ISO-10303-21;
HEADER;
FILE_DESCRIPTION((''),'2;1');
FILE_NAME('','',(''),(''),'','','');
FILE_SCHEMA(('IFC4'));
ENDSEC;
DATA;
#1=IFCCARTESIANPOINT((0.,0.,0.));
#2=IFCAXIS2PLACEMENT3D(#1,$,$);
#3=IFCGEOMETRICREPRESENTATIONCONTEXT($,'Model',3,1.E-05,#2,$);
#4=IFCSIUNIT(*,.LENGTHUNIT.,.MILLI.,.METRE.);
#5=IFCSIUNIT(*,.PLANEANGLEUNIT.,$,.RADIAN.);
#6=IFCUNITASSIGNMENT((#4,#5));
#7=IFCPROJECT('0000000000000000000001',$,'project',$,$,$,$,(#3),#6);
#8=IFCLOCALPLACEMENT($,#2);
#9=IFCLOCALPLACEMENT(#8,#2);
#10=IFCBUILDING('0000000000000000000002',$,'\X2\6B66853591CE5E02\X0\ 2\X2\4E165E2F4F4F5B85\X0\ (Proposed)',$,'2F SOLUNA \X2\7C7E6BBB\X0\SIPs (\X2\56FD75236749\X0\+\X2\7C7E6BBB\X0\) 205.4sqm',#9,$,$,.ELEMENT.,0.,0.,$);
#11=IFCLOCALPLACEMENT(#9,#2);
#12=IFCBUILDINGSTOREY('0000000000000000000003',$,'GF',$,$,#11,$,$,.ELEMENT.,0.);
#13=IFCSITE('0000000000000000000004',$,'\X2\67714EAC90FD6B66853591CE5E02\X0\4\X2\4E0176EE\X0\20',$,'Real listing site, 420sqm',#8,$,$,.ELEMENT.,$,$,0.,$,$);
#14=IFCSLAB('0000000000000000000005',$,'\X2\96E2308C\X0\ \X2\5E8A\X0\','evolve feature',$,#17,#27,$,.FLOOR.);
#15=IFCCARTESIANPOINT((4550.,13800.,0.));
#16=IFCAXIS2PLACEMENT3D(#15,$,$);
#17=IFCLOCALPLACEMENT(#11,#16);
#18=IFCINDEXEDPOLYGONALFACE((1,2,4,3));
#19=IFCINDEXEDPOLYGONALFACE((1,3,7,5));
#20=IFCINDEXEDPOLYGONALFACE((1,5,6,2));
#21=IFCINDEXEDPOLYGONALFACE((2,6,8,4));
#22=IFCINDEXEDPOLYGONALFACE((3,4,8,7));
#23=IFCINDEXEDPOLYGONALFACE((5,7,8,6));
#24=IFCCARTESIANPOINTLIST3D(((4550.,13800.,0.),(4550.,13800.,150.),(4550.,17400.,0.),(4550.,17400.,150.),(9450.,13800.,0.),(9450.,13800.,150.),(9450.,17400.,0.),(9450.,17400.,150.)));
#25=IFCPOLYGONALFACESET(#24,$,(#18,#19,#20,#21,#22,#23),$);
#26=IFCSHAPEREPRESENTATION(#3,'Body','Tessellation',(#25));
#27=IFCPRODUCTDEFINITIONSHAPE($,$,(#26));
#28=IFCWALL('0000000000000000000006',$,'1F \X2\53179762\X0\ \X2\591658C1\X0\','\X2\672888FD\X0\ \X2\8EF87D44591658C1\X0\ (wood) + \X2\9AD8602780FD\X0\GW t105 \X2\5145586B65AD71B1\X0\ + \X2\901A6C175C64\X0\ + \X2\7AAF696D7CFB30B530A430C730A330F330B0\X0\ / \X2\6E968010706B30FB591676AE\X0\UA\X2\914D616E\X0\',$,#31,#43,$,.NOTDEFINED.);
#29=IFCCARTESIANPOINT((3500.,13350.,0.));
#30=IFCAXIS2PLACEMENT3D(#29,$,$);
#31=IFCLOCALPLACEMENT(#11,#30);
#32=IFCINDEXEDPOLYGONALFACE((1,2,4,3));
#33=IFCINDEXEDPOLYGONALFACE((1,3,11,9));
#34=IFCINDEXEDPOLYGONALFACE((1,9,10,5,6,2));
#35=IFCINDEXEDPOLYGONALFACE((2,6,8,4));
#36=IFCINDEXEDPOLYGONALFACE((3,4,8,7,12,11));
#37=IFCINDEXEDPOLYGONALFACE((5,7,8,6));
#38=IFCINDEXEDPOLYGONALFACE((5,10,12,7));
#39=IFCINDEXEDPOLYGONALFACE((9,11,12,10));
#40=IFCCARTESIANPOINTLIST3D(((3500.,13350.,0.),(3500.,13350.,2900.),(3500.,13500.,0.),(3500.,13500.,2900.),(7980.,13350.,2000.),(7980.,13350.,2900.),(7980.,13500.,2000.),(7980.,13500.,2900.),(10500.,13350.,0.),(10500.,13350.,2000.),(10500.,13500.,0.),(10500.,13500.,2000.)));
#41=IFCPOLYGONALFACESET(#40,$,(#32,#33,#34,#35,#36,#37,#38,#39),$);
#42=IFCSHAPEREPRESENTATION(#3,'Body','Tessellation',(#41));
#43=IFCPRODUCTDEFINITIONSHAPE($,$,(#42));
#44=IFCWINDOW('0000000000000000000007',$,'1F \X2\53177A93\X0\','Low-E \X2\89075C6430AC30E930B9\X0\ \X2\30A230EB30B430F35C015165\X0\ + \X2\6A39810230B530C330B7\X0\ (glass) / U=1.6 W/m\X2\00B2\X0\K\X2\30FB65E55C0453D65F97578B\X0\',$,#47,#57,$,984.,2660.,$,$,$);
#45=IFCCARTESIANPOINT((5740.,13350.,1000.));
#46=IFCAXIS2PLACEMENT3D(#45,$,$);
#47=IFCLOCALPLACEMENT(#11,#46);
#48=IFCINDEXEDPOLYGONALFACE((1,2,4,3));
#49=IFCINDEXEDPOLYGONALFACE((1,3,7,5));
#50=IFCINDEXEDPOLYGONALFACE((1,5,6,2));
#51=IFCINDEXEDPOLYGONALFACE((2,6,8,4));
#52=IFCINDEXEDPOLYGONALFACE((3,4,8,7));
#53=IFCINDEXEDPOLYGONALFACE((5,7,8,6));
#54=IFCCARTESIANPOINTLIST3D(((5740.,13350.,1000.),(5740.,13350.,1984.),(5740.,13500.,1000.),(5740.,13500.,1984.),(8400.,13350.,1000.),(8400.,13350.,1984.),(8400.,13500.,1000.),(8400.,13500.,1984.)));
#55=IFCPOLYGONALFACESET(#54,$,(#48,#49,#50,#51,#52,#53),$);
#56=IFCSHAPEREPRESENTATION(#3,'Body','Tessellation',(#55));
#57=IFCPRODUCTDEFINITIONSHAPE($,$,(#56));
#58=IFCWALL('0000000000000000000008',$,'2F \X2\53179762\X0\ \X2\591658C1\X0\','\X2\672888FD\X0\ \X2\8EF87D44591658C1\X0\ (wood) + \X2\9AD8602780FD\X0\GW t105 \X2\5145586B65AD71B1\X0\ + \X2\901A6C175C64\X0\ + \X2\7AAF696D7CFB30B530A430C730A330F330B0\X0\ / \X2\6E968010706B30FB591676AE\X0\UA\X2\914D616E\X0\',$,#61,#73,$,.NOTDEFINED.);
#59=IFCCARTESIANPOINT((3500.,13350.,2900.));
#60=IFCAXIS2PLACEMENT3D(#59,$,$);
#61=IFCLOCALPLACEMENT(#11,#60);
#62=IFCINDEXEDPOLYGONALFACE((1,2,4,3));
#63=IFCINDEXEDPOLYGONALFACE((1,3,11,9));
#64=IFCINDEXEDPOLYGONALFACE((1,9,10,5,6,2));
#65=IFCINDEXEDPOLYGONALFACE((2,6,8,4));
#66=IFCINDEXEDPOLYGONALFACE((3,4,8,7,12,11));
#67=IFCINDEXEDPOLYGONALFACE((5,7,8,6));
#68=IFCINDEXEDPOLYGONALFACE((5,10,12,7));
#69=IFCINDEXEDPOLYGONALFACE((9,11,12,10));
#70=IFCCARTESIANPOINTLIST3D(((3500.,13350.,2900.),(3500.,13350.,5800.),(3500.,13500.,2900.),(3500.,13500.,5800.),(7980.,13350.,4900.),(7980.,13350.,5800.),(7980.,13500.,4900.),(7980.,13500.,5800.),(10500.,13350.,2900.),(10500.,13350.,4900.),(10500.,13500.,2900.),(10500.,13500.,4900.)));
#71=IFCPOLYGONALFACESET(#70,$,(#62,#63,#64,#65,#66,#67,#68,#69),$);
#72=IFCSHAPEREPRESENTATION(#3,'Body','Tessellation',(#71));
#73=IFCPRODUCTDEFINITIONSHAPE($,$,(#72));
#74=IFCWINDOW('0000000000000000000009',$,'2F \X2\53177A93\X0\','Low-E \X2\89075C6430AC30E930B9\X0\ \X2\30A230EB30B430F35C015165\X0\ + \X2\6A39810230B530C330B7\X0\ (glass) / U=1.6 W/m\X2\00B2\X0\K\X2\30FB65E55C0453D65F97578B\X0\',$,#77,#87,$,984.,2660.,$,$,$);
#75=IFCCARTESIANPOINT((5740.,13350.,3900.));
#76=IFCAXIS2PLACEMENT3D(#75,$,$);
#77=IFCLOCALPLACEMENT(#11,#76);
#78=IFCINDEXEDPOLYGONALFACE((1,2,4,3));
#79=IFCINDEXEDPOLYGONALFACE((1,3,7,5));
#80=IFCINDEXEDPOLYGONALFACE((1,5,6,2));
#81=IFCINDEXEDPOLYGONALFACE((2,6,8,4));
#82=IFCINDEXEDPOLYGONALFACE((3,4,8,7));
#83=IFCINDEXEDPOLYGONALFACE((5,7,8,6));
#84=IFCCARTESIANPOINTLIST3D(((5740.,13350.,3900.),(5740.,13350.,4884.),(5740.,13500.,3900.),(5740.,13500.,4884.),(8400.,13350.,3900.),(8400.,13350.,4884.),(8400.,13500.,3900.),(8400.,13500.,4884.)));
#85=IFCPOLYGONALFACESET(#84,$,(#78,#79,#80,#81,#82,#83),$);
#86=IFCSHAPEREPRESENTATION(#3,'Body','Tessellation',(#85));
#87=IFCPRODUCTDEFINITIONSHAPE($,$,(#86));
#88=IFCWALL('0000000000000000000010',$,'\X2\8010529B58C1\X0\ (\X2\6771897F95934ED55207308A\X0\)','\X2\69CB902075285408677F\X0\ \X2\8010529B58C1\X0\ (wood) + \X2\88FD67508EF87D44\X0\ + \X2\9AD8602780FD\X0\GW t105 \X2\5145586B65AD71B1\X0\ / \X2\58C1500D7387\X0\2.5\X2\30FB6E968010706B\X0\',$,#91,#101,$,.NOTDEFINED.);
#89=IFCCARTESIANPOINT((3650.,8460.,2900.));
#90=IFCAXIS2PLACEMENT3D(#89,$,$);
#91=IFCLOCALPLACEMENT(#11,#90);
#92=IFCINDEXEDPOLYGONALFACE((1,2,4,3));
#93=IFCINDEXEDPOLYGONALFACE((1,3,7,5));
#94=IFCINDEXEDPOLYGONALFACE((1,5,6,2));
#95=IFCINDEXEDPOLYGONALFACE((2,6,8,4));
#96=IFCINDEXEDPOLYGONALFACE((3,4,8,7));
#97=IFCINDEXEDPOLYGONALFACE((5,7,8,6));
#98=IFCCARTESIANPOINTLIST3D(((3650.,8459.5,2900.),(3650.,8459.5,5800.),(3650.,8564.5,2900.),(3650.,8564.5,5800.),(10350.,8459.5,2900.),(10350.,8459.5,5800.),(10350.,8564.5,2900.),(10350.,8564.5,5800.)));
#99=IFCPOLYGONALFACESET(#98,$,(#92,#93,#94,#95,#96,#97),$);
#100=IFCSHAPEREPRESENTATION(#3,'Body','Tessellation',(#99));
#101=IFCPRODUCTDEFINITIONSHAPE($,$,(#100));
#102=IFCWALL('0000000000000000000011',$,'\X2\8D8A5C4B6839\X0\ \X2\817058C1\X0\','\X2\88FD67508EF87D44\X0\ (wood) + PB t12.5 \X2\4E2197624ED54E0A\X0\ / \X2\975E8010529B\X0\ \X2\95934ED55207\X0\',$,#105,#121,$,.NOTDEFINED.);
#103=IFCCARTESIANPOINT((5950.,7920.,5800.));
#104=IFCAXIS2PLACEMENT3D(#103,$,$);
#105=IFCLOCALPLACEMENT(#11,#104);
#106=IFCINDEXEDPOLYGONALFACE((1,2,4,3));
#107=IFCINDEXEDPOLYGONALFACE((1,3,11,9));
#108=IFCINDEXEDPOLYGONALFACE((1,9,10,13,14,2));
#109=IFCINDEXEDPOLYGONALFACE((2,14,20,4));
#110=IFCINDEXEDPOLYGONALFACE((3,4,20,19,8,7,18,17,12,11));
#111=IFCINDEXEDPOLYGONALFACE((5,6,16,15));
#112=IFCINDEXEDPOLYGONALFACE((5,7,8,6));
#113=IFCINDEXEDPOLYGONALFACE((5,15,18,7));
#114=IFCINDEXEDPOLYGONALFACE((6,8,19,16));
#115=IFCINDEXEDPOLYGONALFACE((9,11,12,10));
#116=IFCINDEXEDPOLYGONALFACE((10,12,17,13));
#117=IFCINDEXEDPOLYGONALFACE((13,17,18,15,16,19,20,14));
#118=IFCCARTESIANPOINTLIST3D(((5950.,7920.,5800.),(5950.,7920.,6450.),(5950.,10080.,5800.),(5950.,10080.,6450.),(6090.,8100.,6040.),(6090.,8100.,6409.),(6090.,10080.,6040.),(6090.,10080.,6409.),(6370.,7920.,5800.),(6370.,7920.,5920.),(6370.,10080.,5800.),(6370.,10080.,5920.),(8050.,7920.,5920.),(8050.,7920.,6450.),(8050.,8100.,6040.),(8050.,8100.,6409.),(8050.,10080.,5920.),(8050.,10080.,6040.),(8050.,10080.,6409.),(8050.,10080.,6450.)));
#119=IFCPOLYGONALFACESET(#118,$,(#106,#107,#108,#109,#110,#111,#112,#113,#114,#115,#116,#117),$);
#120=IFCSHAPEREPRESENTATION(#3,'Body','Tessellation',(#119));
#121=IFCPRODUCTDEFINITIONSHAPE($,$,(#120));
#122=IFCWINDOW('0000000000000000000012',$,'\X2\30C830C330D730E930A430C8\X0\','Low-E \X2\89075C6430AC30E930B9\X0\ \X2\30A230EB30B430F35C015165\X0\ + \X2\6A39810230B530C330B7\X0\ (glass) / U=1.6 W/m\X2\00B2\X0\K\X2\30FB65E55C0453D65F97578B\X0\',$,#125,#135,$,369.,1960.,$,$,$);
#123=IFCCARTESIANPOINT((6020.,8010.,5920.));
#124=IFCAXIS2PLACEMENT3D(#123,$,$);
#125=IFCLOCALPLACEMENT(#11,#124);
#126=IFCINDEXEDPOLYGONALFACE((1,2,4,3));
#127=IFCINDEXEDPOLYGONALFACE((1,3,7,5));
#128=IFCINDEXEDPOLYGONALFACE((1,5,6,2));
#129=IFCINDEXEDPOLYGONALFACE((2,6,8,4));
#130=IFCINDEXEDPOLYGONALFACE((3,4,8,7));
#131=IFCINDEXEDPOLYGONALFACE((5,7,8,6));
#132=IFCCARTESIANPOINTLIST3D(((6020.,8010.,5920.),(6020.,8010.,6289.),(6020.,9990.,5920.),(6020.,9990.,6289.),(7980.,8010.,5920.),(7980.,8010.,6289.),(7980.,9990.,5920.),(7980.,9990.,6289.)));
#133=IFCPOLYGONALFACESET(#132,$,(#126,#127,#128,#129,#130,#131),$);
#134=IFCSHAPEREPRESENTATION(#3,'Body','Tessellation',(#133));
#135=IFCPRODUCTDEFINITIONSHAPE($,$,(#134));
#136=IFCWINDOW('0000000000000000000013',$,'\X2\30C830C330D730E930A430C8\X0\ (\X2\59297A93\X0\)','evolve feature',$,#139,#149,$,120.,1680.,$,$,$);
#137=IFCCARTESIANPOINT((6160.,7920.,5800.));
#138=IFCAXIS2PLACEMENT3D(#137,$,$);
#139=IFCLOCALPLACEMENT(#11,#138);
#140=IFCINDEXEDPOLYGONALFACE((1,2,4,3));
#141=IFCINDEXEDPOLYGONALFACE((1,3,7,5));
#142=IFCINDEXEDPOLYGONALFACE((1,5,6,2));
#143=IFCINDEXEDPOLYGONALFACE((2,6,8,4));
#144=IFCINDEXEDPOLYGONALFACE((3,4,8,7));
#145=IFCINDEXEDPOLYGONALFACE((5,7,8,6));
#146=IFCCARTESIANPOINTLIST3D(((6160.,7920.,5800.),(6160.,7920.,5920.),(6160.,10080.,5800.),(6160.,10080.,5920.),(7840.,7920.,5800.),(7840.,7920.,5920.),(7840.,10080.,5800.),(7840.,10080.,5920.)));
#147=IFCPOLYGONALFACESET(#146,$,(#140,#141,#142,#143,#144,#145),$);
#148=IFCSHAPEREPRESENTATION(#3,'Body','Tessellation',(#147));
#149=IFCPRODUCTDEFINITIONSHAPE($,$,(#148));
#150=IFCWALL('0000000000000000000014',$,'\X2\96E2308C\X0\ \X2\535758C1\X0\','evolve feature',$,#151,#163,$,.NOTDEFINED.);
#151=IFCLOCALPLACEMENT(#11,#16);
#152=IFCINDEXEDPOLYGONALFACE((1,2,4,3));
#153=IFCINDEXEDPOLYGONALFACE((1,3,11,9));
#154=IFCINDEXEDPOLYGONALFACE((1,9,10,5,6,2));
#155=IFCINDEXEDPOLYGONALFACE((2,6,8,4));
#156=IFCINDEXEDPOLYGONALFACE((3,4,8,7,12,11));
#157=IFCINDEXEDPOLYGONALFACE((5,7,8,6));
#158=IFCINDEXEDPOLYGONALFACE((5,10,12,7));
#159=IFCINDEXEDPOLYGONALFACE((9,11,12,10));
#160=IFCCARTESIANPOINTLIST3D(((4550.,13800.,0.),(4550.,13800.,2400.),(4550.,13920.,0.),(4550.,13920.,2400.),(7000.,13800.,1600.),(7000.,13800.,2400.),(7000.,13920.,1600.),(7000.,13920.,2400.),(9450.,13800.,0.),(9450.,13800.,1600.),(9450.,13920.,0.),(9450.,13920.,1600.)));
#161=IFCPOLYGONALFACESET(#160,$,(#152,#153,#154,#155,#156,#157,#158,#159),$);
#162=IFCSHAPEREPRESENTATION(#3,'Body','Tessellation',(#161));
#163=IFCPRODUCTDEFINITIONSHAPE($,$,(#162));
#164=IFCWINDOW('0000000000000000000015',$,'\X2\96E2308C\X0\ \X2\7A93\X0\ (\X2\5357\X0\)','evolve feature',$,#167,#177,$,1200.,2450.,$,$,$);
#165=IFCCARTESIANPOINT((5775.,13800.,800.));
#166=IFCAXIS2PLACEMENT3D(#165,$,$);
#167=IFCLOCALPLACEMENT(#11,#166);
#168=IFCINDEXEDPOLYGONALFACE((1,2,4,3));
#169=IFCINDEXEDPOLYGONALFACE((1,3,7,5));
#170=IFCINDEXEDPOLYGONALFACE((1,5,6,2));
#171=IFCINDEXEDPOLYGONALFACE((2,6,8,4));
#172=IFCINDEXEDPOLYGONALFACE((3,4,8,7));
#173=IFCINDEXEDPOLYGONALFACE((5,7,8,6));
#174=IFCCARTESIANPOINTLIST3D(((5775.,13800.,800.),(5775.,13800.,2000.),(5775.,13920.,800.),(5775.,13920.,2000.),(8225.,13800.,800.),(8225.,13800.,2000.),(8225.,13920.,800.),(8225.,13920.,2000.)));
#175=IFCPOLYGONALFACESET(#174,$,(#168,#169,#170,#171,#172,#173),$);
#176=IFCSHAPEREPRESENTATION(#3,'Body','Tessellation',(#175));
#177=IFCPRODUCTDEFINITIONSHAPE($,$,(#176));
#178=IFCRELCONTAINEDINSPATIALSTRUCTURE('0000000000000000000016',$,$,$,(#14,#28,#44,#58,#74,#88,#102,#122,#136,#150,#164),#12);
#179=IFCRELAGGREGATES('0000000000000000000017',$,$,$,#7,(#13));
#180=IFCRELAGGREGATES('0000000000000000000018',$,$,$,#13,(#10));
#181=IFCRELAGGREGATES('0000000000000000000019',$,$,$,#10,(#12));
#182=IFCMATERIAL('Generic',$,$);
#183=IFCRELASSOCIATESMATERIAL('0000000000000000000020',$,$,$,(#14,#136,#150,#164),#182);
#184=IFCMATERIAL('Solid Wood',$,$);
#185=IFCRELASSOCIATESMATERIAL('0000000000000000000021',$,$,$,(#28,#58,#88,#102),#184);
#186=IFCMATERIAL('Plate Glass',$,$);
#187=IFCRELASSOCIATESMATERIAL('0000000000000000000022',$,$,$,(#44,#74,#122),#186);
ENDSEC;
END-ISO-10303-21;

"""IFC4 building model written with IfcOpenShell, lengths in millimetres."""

from ifc_helpers import new_model, si_unit, frame, frame_2d, origin, place, context, project, spatial, rectangle, extrude, material, element, fill, save


model = new_model("IFC4")

# Units and contexts
model_context = context("Model", 3, precision=1e-05, world=origin())
ifc_project = project(units=[si_unit("LENGTHUNIT", "METRE", prefix="MILLI"), si_unit("PLANEANGLEUNIT", "RADIAN")], contexts=[model_context])

# Site, building, storey
site_placement = place(None, origin())
site = spatial("IfcSite", under=ifc_project, at=site_placement, Name="東京都武蔵野市4丁目20", ObjectType="Real listing site, 420sqm", CompositionType="ELEMENT", RefElevation=0.0)
building_placement = place(site_placement, origin())
building = spatial("IfcBuilding", under=site, at=building_placement, Name="武蔵野市 2世帯住宅 (Proposed)", ObjectType="2F SOLUNA 籾殻SIPs (国産杉+籾殻) 205.4sqm", CompositionType="ELEMENT", ElevationOfRefHeight=0.0, ElevationOfTerrain=0.0)
storey_placement = place(building_placement, origin())
storey = spatial("IfcBuildingStorey", under=building, at=storey_placement, Name="GF", CompositionType="ELEMENT", Elevation=0.0)

# Slab
ifc_material_1 = material(Name="Generic")
slab_placement = place(storey_placement, frame((4550.0, 13800.0, 0.0)))
element("IfcSlab", 1, at=slab_placement, inside=storey, material=ifc_material_1, Name="離れ 床", Description="evolve feature", PredefinedType="FLOOR", context=model_context, shape_type="SweptSolid", body=[
    extrude(rectangle(XDim=4900.0, YDim=3600.0, at=frame_2d((2450.0, 1800.0))), frame((4550.0, 13800.0, 0.0)), (0.0, 0.0, 1.0), 150.0),
])

# Wall, opening, window
ifc_material_2 = material(Name="Solid Wood")
wall_1_placement = place(storey_placement, frame((3500.0, 13350.0, 0.0)))
wall_1 = element("IfcWall", 2, at=wall_1_placement, inside=storey, material=ifc_material_2, Name="1F 北面 外壁", Description="木製 軸組外壁 (wood) + 高性能GW t105 充填断熱 + 通気層 + 窯業系サイディング / 準耐火・外皮UA配慮", PredefinedType="NOTDEFINED", context=model_context, shape_type="SweptSolid", body=[
    extrude(rectangle(XDim=7000.0, YDim=150.0, at=frame_2d((3500.0, 75.0))), frame((3500.0, 13350.0, 0.0)), (0.0, 0.0, 1.0), 2900.0),
])
opening_1_placement = place(storey_placement, frame((5740.0, 13350.0, 1000.0)))
opening_1 = element("IfcOpeningElement", 3, at=opening_1_placement, cuts=wall_1, PredefinedType="NOTDEFINED", context=model_context, shape_type="SweptSolid", body=[
    extrude(rectangle(XDim=2660.0, YDim=150.0, at=frame_2d((1330.0, 75.0))), frame((5740.0, 13350.0, 1000.0)), (0.0, 0.0, 1.0), 984.0),
])
ifc_material_3 = material(Name="Plate Glass")
window_1_placement = place(storey_placement, frame((5740.0, 13350.0, 1000.0)))
window_1 = element("IfcWindow", 4, at=window_1_placement, inside=storey, material=ifc_material_3, Name="1F 北窓", Description="Low-E 複層ガラス アルゴン封入 + 樹脂サッシ (glass) / U=1.6 W/m²K・日射取得型", OverallHeight=984.0, OverallWidth=2660.0, context=model_context, shape_type="SweptSolid", body=[
    extrude(rectangle(XDim=2660.0, YDim=150.0, at=frame_2d((1330.0, 75.0))), frame((5740.0, 13350.0, 1000.0)), (0.0, 0.0, 1.0), 984.0),
])
fill(opening_1, window_1)

# Wall, opening, window
wall_2_placement = place(storey_placement, frame((3500.0, 13350.0, 2900.0)))
wall_2 = element("IfcWall", 5, at=wall_2_placement, inside=storey, material=ifc_material_2, Name="2F 北面 外壁", Description="木製 軸組外壁 (wood) + 高性能GW t105 充填断熱 + 通気層 + 窯業系サイディング / 準耐火・外皮UA配慮", PredefinedType="NOTDEFINED", context=model_context, shape_type="SweptSolid", body=[
    extrude(rectangle(XDim=7000.0, YDim=150.0, at=frame_2d((3500.0, 75.0))), frame((3500.0, 13350.0, 2900.0)), (0.0, 0.0, 1.0), 2900.0),
])
opening_2_placement = place(storey_placement, frame((5740.0, 13350.0, 3900.0)))
opening_2 = element("IfcOpeningElement", 6, at=opening_2_placement, cuts=wall_2, PredefinedType="NOTDEFINED", context=model_context, shape_type="SweptSolid", body=[
    extrude(rectangle(XDim=2660.0, YDim=150.0, at=frame_2d((1330.0, 75.0))), frame((5740.0, 13350.0, 3900.0)), (0.0, 0.0, 1.0), 984.0),
])
window_2_placement = place(storey_placement, frame((5740.0, 13350.0, 3900.0)))
window_2 = element("IfcWindow", 7, at=window_2_placement, inside=storey, material=ifc_material_3, Name="2F 北窓", Description="Low-E 複層ガラス アルゴン封入 + 樹脂サッシ (glass) / U=1.6 W/m²K・日射取得型", OverallHeight=984.0, OverallWidth=2660.0, context=model_context, shape_type="SweptSolid", body=[
    extrude(rectangle(XDim=2660.0, YDim=150.0, at=frame_2d((1330.0, 75.0))), frame((5740.0, 13350.0, 3900.0)), (0.0, 0.0, 1.0), 984.0),
])
fill(opening_2, window_2)

# Wall
wall_3_placement = place(storey_placement, frame((3650.0, 8460.0, 2900.0)))
element("IfcWall", 8, at=wall_3_placement, inside=storey, material=ifc_material_2, Name="耐力壁 (東西間仕切り)", Description="構造用合板 耐力壁 (wood) + 製材軸組 + 高性能GW t105 充填断熱 / 壁倍率2.5・準耐火", PredefinedType="NOTDEFINED", context=model_context, shape_type="SweptSolid", body=[
    extrude(rectangle(XDim=6700.0, YDim=105.0, at=frame_2d((3350.0, 52.0))), frame((3650.0, 8460.0, 2900.0)), (0.0, 0.0, 1.0), 2900.0),
])

# Wall, openings, windows
wall_4_placement = place(storey_placement, frame((5950.0, 7920.0, 5800.0)))
wall_4 = element("IfcWall", 9, at=wall_4_placement, inside=storey, material=ifc_material_2, Name="越屋根 腰壁", Description="製材軸組 (wood) + PB t12.5 両面仕上 / 非耐力 間仕切", PredefinedType="NOTDEFINED", context=model_context, shape_type="SweptSolid", body=[
    extrude(rectangle(XDim=2100.0, YDim=2160.0, at=frame_2d((1050.0, 1080.0))), frame((5950.0, 7920.0, 5800.0)), (0.0, 0.0, 1.0), 650.0),
])
opening_3_placement = place(storey_placement, frame((6020.0, 8010.0, 5920.0)))
opening_3 = element("IfcOpeningElement", 10, at=opening_3_placement, cuts=wall_4, PredefinedType="NOTDEFINED", context=model_context, shape_type="SweptSolid", body=[
    extrude(rectangle(XDim=1960.0, YDim=1980.0, at=frame_2d((980.0, 990.0))), frame((6020.0, 8010.0, 5920.0)), (0.0, 0.0, 1.0), 369.0),
])
opening_4_placement = place(storey_placement, frame((6160.0, 7920.0, 5800.0)))
opening_4 = element("IfcOpeningElement", 11, at=opening_4_placement, cuts=wall_4, PredefinedType="NOTDEFINED", context=model_context, shape_type="SweptSolid", body=[
    extrude(rectangle(XDim=1680.0, YDim=2160.0, at=frame_2d((840.0, 1080.0))), frame((6160.0, 7920.0, 5800.0)), (0.0, 0.0, 1.0), 120.0),
])
window_3_placement = place(storey_placement, frame((6020.0, 8010.0, 5920.0)))
window_3 = element("IfcWindow", 12, at=window_3_placement, inside=storey, material=ifc_material_3, Name="トップライト", Description="Low-E 複層ガラス アルゴン封入 + 樹脂サッシ (glass) / U=1.6 W/m²K・日射取得型", OverallHeight=369.0, OverallWidth=1960.0, context=model_context, shape_type="SweptSolid", body=[
    extrude(rectangle(XDim=1960.0, YDim=1980.0, at=frame_2d((980.0, 990.0))), frame((6020.0, 8010.0, 5920.0)), (0.0, 0.0, 1.0), 369.0),
])
fill(opening_3, window_3)
window_4_placement = place(storey_placement, frame((6160.0, 7920.0, 5800.0)))
window_4 = element("IfcWindow", 13, at=window_4_placement, inside=storey, material=ifc_material_1, Name="トップライト (天窓)", Description="evolve feature", OverallHeight=120.0, OverallWidth=1680.0, context=model_context, shape_type="SweptSolid", body=[
    extrude(rectangle(XDim=1680.0, YDim=2160.0, at=frame_2d((840.0, 1080.0))), frame((6160.0, 7920.0, 5800.0)), (0.0, 0.0, 1.0), 120.0),
])
fill(opening_4, window_4)

# Wall, opening, window
wall_5_placement = place(storey_placement, frame((4550.0, 13800.0, 0.0)))
wall_5 = element("IfcWall", 14, at=wall_5_placement, inside=storey, material=ifc_material_1, Name="離れ 南壁", Description="evolve feature", PredefinedType="NOTDEFINED", context=model_context, shape_type="SweptSolid", body=[
    extrude(rectangle(XDim=4900.0, YDim=120.0, at=frame_2d((2450.0, 60.0))), frame((4550.0, 13800.0, 0.0)), (0.0, 0.0, 1.0), 2400.0),
])
opening_5_placement = place(storey_placement, frame((5775.0, 13800.0, 800.0)))
opening_5 = element("IfcOpeningElement", 15, at=opening_5_placement, cuts=wall_5, PredefinedType="NOTDEFINED", context=model_context, shape_type="SweptSolid", body=[
    extrude(rectangle(XDim=2450.0, YDim=120.0, at=frame_2d((1225.0, 60.0))), frame((5775.0, 13800.0, 800.0)), (0.0, 0.0, 1.0), 1200.0),
])
window_5_placement = place(storey_placement, frame((5775.0, 13800.0, 800.0)))
window_5 = element("IfcWindow", 16, at=window_5_placement, inside=storey, material=ifc_material_1, Name="離れ 窓 (南)", Description="evolve feature", OverallHeight=1200.0, OverallWidth=2450.0, context=model_context, shape_type="SweptSolid", body=[
    extrude(rectangle(XDim=2450.0, YDim=120.0, at=frame_2d((1225.0, 60.0))), frame((5775.0, 13800.0, 800.0)), (0.0, 0.0, 1.0), 1200.0),
])
fill(opening_5, window_5)

save(model, "model.ifc")
